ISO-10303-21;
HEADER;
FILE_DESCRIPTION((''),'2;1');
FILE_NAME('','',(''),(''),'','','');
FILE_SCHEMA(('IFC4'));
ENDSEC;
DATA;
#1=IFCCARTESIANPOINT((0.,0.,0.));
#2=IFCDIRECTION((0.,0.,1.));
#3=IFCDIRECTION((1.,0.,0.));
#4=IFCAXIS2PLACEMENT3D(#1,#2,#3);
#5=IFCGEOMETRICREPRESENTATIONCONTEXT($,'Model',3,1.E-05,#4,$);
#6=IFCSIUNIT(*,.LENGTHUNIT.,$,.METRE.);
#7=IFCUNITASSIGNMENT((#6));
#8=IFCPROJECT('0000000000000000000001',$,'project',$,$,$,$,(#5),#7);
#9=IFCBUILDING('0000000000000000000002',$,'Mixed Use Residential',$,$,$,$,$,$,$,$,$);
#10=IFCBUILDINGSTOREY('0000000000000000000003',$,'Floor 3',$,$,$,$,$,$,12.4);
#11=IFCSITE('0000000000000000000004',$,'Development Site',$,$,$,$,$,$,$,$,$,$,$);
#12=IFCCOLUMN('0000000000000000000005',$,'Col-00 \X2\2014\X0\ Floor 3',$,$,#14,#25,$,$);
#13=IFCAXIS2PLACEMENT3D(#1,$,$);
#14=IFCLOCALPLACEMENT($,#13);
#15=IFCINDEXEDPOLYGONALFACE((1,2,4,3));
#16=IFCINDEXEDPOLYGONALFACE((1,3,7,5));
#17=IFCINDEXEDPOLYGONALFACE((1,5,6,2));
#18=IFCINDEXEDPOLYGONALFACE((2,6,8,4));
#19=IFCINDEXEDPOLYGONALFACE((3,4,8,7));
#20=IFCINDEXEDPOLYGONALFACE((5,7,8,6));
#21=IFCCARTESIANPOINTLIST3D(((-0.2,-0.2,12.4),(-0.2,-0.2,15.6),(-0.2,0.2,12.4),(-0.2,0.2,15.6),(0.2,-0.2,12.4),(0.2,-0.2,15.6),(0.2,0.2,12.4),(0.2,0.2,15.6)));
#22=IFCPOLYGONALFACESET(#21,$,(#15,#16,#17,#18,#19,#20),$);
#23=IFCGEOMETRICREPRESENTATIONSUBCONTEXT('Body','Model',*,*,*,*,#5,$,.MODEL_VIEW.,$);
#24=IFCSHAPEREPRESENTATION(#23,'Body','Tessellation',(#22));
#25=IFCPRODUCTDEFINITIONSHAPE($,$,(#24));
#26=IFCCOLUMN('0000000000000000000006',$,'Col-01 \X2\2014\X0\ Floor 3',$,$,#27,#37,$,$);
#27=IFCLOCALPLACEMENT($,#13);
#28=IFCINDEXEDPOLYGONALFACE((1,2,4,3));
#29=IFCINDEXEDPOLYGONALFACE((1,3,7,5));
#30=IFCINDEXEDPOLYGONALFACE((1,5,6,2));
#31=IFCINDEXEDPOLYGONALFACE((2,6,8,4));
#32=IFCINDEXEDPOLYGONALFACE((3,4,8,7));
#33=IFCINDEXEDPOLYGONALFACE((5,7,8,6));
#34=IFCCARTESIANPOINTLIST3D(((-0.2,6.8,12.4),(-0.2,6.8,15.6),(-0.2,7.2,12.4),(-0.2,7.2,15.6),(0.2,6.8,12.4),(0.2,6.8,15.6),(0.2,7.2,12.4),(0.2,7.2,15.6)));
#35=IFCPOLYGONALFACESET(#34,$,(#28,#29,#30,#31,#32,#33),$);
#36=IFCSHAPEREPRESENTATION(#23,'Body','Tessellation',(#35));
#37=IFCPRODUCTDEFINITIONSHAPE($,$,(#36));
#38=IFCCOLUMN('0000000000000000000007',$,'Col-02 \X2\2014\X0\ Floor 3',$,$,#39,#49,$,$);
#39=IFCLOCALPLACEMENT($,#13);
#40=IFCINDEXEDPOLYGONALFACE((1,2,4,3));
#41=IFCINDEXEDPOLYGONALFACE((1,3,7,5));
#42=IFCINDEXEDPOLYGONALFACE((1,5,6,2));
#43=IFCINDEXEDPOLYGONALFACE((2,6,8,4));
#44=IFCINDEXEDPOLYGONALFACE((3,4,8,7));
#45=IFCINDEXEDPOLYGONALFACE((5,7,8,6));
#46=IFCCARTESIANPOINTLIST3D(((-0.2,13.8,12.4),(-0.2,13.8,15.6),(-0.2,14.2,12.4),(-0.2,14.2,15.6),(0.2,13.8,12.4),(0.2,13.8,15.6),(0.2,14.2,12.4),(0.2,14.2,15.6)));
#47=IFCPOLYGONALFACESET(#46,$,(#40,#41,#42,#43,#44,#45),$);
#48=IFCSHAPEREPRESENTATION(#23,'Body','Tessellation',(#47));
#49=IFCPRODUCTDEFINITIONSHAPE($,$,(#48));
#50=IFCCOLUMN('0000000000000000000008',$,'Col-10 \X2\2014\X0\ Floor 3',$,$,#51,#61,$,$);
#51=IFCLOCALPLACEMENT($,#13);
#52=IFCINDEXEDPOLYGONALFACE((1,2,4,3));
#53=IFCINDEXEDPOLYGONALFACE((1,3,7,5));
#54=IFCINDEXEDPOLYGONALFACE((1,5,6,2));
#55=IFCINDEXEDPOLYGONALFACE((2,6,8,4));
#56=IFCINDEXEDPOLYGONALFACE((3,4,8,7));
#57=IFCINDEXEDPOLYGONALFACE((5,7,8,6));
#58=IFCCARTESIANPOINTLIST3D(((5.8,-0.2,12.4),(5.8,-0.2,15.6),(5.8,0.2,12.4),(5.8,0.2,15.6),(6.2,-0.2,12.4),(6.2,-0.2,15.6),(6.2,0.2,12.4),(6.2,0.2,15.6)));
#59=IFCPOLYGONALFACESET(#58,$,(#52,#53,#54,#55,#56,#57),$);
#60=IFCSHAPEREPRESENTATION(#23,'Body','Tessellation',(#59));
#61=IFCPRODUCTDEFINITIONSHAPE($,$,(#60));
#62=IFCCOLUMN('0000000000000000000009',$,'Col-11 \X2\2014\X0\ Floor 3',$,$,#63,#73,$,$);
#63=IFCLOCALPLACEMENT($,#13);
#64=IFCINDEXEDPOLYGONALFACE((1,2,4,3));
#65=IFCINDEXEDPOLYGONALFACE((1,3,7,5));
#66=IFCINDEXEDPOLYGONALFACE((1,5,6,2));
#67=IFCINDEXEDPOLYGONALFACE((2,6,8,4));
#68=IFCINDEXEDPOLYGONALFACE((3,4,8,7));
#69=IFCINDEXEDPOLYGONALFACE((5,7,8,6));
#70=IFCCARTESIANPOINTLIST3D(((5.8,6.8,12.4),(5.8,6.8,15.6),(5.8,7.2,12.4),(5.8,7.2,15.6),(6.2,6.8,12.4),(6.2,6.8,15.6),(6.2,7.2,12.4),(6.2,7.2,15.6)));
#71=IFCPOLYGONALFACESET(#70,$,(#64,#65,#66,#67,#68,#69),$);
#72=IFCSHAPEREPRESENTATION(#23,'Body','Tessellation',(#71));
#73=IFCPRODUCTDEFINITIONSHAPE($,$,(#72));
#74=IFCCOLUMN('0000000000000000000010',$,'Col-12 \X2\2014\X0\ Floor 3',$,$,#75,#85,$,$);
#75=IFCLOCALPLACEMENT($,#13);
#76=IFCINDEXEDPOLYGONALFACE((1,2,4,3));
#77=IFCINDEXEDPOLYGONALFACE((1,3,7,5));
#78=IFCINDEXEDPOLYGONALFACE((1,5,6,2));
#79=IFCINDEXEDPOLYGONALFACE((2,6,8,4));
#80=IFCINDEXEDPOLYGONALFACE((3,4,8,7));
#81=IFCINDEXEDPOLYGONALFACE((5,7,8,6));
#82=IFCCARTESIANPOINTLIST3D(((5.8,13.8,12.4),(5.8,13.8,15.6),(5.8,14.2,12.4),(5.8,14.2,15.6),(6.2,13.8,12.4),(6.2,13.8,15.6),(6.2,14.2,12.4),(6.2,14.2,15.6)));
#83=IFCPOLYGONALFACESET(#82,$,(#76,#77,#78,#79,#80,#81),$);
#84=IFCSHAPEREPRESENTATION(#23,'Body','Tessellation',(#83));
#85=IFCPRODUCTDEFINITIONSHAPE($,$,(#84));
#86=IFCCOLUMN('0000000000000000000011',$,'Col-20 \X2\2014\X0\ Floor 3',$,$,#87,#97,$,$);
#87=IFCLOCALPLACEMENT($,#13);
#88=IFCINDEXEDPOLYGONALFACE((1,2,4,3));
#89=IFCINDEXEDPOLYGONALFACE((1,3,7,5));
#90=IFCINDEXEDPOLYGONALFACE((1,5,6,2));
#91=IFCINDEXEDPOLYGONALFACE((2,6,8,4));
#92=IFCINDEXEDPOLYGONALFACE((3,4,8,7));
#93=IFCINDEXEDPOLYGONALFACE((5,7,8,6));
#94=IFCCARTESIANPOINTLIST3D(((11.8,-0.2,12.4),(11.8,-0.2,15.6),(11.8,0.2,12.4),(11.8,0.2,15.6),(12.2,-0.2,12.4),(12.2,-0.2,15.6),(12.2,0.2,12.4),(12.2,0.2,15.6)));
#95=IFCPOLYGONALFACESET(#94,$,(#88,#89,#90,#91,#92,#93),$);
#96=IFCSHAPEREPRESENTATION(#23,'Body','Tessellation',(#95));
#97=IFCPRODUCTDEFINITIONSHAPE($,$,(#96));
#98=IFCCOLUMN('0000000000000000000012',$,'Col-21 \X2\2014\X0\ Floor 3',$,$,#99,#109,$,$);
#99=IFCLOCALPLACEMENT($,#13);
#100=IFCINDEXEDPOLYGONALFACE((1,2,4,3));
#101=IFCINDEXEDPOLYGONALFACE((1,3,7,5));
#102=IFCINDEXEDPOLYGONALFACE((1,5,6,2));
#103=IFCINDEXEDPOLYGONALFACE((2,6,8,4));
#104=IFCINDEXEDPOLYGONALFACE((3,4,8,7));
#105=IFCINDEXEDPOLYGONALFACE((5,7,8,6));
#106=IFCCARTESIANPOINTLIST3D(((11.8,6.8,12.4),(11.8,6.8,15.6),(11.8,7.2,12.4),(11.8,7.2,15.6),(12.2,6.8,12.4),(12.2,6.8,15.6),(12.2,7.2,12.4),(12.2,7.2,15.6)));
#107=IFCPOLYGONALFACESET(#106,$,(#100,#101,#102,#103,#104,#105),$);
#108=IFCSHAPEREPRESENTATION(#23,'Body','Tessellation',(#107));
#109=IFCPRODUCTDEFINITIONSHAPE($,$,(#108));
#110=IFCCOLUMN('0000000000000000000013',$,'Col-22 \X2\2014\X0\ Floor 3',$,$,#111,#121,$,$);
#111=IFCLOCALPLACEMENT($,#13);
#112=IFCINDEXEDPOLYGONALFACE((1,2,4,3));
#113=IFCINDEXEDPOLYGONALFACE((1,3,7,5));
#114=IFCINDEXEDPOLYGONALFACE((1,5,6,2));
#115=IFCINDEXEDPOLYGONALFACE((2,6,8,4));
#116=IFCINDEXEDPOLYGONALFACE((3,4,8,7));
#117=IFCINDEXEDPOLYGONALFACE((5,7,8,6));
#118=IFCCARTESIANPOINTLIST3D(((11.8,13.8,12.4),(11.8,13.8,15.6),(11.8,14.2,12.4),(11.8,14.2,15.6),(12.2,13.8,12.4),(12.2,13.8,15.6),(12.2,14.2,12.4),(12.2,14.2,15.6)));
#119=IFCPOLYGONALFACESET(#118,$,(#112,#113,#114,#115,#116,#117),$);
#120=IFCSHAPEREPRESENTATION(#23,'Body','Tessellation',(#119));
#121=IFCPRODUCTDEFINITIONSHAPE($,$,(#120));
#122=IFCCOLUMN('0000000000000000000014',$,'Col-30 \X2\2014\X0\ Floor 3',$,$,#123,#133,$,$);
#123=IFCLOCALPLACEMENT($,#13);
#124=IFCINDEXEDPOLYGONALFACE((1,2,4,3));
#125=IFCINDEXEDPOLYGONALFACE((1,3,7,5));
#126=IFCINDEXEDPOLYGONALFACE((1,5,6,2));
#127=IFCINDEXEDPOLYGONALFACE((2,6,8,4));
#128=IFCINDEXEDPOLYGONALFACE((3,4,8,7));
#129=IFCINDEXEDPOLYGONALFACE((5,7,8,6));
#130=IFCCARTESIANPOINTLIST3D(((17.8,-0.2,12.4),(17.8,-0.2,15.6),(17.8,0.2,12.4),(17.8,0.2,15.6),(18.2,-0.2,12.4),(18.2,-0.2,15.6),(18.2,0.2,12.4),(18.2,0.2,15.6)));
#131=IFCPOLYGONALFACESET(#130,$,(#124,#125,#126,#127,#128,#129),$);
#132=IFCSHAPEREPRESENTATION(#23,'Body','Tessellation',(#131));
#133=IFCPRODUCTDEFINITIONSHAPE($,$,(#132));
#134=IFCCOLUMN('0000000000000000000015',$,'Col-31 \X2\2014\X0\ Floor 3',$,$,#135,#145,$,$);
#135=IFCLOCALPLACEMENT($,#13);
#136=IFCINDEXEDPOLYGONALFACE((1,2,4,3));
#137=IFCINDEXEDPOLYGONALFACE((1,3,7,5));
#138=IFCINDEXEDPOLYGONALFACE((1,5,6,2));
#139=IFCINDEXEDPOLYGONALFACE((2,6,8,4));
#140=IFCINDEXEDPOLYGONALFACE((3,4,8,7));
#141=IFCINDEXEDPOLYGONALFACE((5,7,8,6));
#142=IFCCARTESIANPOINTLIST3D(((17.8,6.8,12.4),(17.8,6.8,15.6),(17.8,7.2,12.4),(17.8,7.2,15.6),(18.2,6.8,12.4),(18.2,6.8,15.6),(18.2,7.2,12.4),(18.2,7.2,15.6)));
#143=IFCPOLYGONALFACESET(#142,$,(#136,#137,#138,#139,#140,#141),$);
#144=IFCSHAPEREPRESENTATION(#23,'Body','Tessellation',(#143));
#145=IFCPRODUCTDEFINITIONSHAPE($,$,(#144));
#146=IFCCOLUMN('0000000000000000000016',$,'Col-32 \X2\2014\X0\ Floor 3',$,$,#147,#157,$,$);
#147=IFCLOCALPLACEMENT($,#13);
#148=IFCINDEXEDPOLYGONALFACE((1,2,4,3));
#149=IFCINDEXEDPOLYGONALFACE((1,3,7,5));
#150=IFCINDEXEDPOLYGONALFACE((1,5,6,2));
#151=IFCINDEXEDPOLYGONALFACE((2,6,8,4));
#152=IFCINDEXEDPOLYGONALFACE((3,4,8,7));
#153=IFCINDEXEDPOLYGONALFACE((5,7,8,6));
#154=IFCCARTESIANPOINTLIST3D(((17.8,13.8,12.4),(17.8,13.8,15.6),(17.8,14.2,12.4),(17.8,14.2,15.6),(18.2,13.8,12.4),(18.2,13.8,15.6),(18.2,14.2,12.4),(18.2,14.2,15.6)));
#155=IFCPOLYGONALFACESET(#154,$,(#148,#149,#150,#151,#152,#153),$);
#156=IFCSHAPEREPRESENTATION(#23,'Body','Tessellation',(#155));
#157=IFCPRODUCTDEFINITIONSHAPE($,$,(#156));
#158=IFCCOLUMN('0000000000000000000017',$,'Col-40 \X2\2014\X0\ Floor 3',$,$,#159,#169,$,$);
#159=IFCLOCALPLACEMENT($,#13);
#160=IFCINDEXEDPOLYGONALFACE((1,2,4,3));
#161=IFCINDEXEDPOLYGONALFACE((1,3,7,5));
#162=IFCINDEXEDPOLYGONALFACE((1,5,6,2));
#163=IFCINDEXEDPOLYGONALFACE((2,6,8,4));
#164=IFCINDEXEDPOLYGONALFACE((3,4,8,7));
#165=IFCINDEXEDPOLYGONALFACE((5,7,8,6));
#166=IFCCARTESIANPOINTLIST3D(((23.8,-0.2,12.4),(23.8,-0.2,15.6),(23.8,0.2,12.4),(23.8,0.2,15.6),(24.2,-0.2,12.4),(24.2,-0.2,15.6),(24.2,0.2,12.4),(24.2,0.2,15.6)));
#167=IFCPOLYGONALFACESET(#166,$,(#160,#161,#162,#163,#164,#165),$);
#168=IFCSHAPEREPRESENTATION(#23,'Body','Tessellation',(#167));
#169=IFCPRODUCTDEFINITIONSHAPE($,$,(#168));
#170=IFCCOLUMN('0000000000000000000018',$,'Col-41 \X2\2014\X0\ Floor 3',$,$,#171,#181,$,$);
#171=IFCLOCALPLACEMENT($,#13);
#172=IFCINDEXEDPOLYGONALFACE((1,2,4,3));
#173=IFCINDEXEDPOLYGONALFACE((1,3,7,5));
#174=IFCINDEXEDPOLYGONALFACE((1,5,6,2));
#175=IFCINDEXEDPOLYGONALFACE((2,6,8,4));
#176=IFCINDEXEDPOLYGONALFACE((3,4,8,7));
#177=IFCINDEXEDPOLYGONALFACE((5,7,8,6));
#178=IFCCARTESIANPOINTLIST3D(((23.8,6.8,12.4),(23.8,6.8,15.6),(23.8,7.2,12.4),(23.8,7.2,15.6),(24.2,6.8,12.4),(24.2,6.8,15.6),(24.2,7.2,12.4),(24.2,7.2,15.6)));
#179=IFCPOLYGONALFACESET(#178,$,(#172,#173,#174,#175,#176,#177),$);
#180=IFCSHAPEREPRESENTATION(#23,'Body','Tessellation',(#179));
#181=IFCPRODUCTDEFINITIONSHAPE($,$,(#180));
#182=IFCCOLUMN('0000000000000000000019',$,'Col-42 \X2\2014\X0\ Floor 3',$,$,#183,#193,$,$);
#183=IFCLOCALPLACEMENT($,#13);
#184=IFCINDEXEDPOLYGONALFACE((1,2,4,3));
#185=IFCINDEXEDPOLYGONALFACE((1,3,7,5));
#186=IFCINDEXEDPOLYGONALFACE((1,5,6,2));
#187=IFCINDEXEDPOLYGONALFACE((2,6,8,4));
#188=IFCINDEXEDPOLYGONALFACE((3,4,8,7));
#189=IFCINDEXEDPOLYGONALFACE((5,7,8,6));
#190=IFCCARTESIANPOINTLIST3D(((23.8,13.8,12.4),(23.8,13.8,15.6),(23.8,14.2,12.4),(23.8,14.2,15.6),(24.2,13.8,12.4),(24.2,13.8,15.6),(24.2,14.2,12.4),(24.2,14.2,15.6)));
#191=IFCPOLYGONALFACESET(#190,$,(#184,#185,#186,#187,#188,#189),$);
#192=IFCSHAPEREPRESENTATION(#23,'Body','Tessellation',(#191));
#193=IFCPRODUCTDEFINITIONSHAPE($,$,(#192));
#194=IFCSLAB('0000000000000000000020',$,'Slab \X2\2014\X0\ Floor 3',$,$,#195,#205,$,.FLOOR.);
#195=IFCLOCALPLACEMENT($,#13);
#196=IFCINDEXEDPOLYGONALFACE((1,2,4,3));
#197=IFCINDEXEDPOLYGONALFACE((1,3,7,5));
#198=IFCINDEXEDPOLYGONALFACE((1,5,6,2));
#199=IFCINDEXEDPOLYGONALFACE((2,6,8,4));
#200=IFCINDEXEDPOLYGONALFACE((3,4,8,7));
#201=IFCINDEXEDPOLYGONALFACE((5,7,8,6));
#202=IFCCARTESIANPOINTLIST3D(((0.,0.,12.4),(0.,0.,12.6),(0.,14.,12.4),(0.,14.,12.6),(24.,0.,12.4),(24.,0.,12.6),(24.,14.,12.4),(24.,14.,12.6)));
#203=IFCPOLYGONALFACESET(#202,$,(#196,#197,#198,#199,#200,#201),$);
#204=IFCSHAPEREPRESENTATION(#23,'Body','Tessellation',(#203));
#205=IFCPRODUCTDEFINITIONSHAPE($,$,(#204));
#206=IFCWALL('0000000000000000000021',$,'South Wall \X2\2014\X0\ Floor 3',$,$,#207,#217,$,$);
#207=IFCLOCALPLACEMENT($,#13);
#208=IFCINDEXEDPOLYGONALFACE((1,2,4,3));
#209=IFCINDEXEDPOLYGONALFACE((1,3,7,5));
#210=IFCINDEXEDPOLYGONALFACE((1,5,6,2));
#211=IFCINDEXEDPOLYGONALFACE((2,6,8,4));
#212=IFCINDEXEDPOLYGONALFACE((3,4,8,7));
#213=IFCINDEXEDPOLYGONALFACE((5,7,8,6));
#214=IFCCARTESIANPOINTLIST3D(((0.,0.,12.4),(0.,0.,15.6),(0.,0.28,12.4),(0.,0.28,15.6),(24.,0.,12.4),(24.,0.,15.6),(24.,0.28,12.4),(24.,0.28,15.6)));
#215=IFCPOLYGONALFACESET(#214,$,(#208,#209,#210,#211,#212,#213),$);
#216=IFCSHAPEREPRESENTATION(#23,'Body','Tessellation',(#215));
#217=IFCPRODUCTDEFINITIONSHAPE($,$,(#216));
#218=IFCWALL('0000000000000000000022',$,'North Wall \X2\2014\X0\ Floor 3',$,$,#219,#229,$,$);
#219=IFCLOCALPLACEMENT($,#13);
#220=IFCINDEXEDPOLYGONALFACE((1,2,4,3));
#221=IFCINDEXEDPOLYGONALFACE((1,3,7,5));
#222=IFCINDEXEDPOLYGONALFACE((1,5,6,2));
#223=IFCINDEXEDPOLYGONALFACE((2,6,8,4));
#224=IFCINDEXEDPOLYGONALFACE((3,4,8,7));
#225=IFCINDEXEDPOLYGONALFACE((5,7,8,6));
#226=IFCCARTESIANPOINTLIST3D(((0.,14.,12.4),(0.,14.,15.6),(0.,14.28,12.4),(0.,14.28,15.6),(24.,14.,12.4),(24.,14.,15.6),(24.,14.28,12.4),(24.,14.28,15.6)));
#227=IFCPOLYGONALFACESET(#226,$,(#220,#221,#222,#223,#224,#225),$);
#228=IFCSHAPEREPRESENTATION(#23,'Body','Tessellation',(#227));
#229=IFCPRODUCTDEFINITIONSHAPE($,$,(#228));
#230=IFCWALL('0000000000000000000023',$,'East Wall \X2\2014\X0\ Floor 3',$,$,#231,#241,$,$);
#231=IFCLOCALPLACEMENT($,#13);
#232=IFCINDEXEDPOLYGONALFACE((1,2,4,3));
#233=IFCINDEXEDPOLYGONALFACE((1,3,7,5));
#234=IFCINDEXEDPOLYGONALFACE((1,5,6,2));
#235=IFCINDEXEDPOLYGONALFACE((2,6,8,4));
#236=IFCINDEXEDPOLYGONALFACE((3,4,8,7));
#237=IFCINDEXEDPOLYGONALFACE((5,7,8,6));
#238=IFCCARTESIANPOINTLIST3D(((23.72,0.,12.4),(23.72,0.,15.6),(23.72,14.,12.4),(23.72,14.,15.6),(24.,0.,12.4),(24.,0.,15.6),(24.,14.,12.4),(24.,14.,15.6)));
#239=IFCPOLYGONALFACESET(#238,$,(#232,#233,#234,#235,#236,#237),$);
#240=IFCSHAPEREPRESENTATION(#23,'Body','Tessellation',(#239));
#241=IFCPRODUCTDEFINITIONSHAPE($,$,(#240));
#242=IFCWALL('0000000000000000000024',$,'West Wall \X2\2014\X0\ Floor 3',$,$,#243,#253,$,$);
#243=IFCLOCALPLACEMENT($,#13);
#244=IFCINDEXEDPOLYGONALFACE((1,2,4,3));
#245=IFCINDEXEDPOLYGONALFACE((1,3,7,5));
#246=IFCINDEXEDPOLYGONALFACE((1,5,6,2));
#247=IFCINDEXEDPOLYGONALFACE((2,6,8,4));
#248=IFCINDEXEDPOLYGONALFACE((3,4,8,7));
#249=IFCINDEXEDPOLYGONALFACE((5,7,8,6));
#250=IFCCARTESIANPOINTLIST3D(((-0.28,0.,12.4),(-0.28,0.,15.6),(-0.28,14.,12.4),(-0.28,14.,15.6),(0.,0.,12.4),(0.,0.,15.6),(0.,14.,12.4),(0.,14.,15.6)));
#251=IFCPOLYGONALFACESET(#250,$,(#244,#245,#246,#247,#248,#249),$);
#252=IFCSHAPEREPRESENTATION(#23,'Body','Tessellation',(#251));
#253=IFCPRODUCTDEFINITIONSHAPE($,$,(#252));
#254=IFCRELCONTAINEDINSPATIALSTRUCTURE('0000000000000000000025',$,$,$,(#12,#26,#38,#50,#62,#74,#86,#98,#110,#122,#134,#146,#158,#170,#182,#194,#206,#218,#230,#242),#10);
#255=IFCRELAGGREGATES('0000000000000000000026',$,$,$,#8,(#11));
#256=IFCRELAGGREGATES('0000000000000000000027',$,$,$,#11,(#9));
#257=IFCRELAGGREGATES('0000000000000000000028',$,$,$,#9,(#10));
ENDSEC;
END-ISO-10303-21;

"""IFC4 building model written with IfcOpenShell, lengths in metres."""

from ifc_helpers import new_model, si_unit, frame, origin_with_axes, place, context, subcontext, project, spatial, indexed_curve, rectangle, outline, extrude, element, save


model = new_model("IFC4")

# Units and contexts
model_context = context("Model", 3, precision=1e-05, world=origin_with_axes())
body_context = subcontext(model_context, "Body", "Model", "MODEL_VIEW")
ifc_project = project(units=[si_unit("LENGTHUNIT", "METRE")], contexts=[model_context])

# Site, building, storey
site = spatial("IfcSite", under=ifc_project, Name="Development Site")
building = spatial("IfcBuilding", under=site, Name="Mixed Use Residential")
storey = spatial("IfcBuildingStorey", under=building, Name="Floor 3", Elevation=12.4)

# Columns
for number, where, z_axis, x_axis, name in (
    (1, (0.0, 0.0, 12.4), (0.0, 0.0, 1.0), (1.0, 0.0, 0.0), "Col-00 — Floor 3"),
    (2, (0.0, 7.0, 12.4), (0.0, 0.0, 1.0), (1.0, 0.0, 0.0), "Col-01 — Floor 3"),
    (3, (0.0, 14.0, 12.4), (0.0, 0.0, 1.0), (1.0, 0.0, 0.0), "Col-02 — Floor 3"),
    (4, (6.0, 0.0, 12.4), (0.0, 0.0, 1.0), (1.0, 0.0, 0.0), "Col-10 — Floor 3"),
    (5, (6.0, 7.0, 12.4), (0.0, 0.0, 1.0), (1.0, 0.0, 0.0), "Col-11 — Floor 3"),
    (6, (6.0, 14.0, 12.4), (0.0, 0.0, 1.0), (1.0, 0.0, 0.0), "Col-12 — Floor 3"),
    (7, (12.0, 0.0, 12.4), (0.0, 0.0, 1.0), (1.0, 0.0, 0.0), "Col-20 — Floor 3"),
    (8, (12.0, 7.0, 12.4), (0.0, 0.0, 1.0), (1.0, 0.0, 0.0), "Col-21 — Floor 3"),
    (9, (12.0, 14.0, 12.4), (0.0, 0.0, 1.0), (1.0, 0.0, 0.0), "Col-22 — Floor 3"),
    (10, (18.0, 0.0, 12.4), (0.0, 0.0, 1.0), (1.0, 0.0, 0.0), "Col-30 — Floor 3"),
    (11, (18.0, 7.0, 12.4), (0.0, 0.0, 1.0), (1.0, 0.0, 0.0), "Col-31 — Floor 3"),
    (12, (18.0, 14.0, 12.4), (0.0, 0.0, 1.0), (1.0, 0.0, 0.0), "Col-32 — Floor 3"),
    (13, (24.0, 0.0, 12.4), (0.0, 0.0, 1.0), (1.0, 0.0, 0.0), "Col-40 — Floor 3"),
    (14, (24.0, 7.0, 12.4), (0.0, 0.0, 1.0), (1.0, 0.0, 0.0), "Col-41 — Floor 3"),
    (15, (24.0, 14.0, 12.4), (0.0, 0.0, 1.0), (1.0, 0.0, 0.0), "Col-42 — Floor 3"),
):
    element("IfcColumn", number, at=place(None, frame(where, z_axis=z_axis, x_axis=x_axis)), inside=storey, Name=name, context=body_context, shape_type="SweptSolid", body=[
        extrude(rectangle(XDim=0.4, YDim=0.4), origin_with_axes(), (0.0, 0.0, 1.0), 3.2),
    ])

# Slab
slab_placement = place(None, frame((0.0, 0.0, 12.4), z_axis=(0.0, 0.0, 1.0), x_axis=(1.0, 0.0, 0.0)))
element("IfcSlab", 16, at=slab_placement, inside=storey, Name="Slab — Floor 3", PredefinedType="FLOOR", context=body_context, shape_type="SweptSolid", body=[
    extrude(outline(indexed_curve([(0.0, 0.0), (24.0, 0.0), (24.0, 14.0), (0.0, 14.0), (0.0, 0.0)])), None, (0.0, 0.0, 1.0), 0.2),
])

# Walls
for number, where, z_axis, x_axis, name in (
    (17, (0.0, 0.0, 12.4), (0.0, 0.0, 1.0), (1.0, 0.0, 0.0), "South Wall — Floor 3"),
    (18, (0.0, 14.0, 12.4), (0.0, 0.0, 1.0), (1.0, 0.0, 0.0), "North Wall — Floor 3"),
):
    element("IfcWall", number, at=place(None, frame(where, z_axis=z_axis, x_axis=x_axis)), inside=storey, Name=name, context=body_context, shape_type="SweptSolid", body=[
        extrude(outline(indexed_curve([(0.0, 0.0), (0.0, 0.28), (24.0, 0.28), (24.0, 0.0), (0.0, 0.0)], self_intersect=False)), origin_with_axes(), (0.0, 0.0, 1.0), 3.2),
    ])
for number, where, z_axis, x_axis, name in (
    (19, (24.0, 0.0, 12.4), (0.0, 0.0, 1.0), (0.0, 1.0, 0.0), "East Wall — Floor 3"),
    (20, (0.0, 0.0, 12.4), (0.0, 0.0, 1.0), (0.0, 1.0, 0.0), "West Wall — Floor 3"),
):
    element("IfcWall", number, at=place(None, frame(where, z_axis=z_axis, x_axis=x_axis)), inside=storey, Name=name, context=body_context, shape_type="SweptSolid", body=[
        extrude(outline(indexed_curve([(0.0, 0.0), (0.0, 0.28), (14.0, 0.28), (14.0, 0.0), (0.0, 0.0)], self_intersect=False)), origin_with_axes(), (0.0, 0.0, 1.0), 3.2),
    ])

save(model, "model.ifc")
